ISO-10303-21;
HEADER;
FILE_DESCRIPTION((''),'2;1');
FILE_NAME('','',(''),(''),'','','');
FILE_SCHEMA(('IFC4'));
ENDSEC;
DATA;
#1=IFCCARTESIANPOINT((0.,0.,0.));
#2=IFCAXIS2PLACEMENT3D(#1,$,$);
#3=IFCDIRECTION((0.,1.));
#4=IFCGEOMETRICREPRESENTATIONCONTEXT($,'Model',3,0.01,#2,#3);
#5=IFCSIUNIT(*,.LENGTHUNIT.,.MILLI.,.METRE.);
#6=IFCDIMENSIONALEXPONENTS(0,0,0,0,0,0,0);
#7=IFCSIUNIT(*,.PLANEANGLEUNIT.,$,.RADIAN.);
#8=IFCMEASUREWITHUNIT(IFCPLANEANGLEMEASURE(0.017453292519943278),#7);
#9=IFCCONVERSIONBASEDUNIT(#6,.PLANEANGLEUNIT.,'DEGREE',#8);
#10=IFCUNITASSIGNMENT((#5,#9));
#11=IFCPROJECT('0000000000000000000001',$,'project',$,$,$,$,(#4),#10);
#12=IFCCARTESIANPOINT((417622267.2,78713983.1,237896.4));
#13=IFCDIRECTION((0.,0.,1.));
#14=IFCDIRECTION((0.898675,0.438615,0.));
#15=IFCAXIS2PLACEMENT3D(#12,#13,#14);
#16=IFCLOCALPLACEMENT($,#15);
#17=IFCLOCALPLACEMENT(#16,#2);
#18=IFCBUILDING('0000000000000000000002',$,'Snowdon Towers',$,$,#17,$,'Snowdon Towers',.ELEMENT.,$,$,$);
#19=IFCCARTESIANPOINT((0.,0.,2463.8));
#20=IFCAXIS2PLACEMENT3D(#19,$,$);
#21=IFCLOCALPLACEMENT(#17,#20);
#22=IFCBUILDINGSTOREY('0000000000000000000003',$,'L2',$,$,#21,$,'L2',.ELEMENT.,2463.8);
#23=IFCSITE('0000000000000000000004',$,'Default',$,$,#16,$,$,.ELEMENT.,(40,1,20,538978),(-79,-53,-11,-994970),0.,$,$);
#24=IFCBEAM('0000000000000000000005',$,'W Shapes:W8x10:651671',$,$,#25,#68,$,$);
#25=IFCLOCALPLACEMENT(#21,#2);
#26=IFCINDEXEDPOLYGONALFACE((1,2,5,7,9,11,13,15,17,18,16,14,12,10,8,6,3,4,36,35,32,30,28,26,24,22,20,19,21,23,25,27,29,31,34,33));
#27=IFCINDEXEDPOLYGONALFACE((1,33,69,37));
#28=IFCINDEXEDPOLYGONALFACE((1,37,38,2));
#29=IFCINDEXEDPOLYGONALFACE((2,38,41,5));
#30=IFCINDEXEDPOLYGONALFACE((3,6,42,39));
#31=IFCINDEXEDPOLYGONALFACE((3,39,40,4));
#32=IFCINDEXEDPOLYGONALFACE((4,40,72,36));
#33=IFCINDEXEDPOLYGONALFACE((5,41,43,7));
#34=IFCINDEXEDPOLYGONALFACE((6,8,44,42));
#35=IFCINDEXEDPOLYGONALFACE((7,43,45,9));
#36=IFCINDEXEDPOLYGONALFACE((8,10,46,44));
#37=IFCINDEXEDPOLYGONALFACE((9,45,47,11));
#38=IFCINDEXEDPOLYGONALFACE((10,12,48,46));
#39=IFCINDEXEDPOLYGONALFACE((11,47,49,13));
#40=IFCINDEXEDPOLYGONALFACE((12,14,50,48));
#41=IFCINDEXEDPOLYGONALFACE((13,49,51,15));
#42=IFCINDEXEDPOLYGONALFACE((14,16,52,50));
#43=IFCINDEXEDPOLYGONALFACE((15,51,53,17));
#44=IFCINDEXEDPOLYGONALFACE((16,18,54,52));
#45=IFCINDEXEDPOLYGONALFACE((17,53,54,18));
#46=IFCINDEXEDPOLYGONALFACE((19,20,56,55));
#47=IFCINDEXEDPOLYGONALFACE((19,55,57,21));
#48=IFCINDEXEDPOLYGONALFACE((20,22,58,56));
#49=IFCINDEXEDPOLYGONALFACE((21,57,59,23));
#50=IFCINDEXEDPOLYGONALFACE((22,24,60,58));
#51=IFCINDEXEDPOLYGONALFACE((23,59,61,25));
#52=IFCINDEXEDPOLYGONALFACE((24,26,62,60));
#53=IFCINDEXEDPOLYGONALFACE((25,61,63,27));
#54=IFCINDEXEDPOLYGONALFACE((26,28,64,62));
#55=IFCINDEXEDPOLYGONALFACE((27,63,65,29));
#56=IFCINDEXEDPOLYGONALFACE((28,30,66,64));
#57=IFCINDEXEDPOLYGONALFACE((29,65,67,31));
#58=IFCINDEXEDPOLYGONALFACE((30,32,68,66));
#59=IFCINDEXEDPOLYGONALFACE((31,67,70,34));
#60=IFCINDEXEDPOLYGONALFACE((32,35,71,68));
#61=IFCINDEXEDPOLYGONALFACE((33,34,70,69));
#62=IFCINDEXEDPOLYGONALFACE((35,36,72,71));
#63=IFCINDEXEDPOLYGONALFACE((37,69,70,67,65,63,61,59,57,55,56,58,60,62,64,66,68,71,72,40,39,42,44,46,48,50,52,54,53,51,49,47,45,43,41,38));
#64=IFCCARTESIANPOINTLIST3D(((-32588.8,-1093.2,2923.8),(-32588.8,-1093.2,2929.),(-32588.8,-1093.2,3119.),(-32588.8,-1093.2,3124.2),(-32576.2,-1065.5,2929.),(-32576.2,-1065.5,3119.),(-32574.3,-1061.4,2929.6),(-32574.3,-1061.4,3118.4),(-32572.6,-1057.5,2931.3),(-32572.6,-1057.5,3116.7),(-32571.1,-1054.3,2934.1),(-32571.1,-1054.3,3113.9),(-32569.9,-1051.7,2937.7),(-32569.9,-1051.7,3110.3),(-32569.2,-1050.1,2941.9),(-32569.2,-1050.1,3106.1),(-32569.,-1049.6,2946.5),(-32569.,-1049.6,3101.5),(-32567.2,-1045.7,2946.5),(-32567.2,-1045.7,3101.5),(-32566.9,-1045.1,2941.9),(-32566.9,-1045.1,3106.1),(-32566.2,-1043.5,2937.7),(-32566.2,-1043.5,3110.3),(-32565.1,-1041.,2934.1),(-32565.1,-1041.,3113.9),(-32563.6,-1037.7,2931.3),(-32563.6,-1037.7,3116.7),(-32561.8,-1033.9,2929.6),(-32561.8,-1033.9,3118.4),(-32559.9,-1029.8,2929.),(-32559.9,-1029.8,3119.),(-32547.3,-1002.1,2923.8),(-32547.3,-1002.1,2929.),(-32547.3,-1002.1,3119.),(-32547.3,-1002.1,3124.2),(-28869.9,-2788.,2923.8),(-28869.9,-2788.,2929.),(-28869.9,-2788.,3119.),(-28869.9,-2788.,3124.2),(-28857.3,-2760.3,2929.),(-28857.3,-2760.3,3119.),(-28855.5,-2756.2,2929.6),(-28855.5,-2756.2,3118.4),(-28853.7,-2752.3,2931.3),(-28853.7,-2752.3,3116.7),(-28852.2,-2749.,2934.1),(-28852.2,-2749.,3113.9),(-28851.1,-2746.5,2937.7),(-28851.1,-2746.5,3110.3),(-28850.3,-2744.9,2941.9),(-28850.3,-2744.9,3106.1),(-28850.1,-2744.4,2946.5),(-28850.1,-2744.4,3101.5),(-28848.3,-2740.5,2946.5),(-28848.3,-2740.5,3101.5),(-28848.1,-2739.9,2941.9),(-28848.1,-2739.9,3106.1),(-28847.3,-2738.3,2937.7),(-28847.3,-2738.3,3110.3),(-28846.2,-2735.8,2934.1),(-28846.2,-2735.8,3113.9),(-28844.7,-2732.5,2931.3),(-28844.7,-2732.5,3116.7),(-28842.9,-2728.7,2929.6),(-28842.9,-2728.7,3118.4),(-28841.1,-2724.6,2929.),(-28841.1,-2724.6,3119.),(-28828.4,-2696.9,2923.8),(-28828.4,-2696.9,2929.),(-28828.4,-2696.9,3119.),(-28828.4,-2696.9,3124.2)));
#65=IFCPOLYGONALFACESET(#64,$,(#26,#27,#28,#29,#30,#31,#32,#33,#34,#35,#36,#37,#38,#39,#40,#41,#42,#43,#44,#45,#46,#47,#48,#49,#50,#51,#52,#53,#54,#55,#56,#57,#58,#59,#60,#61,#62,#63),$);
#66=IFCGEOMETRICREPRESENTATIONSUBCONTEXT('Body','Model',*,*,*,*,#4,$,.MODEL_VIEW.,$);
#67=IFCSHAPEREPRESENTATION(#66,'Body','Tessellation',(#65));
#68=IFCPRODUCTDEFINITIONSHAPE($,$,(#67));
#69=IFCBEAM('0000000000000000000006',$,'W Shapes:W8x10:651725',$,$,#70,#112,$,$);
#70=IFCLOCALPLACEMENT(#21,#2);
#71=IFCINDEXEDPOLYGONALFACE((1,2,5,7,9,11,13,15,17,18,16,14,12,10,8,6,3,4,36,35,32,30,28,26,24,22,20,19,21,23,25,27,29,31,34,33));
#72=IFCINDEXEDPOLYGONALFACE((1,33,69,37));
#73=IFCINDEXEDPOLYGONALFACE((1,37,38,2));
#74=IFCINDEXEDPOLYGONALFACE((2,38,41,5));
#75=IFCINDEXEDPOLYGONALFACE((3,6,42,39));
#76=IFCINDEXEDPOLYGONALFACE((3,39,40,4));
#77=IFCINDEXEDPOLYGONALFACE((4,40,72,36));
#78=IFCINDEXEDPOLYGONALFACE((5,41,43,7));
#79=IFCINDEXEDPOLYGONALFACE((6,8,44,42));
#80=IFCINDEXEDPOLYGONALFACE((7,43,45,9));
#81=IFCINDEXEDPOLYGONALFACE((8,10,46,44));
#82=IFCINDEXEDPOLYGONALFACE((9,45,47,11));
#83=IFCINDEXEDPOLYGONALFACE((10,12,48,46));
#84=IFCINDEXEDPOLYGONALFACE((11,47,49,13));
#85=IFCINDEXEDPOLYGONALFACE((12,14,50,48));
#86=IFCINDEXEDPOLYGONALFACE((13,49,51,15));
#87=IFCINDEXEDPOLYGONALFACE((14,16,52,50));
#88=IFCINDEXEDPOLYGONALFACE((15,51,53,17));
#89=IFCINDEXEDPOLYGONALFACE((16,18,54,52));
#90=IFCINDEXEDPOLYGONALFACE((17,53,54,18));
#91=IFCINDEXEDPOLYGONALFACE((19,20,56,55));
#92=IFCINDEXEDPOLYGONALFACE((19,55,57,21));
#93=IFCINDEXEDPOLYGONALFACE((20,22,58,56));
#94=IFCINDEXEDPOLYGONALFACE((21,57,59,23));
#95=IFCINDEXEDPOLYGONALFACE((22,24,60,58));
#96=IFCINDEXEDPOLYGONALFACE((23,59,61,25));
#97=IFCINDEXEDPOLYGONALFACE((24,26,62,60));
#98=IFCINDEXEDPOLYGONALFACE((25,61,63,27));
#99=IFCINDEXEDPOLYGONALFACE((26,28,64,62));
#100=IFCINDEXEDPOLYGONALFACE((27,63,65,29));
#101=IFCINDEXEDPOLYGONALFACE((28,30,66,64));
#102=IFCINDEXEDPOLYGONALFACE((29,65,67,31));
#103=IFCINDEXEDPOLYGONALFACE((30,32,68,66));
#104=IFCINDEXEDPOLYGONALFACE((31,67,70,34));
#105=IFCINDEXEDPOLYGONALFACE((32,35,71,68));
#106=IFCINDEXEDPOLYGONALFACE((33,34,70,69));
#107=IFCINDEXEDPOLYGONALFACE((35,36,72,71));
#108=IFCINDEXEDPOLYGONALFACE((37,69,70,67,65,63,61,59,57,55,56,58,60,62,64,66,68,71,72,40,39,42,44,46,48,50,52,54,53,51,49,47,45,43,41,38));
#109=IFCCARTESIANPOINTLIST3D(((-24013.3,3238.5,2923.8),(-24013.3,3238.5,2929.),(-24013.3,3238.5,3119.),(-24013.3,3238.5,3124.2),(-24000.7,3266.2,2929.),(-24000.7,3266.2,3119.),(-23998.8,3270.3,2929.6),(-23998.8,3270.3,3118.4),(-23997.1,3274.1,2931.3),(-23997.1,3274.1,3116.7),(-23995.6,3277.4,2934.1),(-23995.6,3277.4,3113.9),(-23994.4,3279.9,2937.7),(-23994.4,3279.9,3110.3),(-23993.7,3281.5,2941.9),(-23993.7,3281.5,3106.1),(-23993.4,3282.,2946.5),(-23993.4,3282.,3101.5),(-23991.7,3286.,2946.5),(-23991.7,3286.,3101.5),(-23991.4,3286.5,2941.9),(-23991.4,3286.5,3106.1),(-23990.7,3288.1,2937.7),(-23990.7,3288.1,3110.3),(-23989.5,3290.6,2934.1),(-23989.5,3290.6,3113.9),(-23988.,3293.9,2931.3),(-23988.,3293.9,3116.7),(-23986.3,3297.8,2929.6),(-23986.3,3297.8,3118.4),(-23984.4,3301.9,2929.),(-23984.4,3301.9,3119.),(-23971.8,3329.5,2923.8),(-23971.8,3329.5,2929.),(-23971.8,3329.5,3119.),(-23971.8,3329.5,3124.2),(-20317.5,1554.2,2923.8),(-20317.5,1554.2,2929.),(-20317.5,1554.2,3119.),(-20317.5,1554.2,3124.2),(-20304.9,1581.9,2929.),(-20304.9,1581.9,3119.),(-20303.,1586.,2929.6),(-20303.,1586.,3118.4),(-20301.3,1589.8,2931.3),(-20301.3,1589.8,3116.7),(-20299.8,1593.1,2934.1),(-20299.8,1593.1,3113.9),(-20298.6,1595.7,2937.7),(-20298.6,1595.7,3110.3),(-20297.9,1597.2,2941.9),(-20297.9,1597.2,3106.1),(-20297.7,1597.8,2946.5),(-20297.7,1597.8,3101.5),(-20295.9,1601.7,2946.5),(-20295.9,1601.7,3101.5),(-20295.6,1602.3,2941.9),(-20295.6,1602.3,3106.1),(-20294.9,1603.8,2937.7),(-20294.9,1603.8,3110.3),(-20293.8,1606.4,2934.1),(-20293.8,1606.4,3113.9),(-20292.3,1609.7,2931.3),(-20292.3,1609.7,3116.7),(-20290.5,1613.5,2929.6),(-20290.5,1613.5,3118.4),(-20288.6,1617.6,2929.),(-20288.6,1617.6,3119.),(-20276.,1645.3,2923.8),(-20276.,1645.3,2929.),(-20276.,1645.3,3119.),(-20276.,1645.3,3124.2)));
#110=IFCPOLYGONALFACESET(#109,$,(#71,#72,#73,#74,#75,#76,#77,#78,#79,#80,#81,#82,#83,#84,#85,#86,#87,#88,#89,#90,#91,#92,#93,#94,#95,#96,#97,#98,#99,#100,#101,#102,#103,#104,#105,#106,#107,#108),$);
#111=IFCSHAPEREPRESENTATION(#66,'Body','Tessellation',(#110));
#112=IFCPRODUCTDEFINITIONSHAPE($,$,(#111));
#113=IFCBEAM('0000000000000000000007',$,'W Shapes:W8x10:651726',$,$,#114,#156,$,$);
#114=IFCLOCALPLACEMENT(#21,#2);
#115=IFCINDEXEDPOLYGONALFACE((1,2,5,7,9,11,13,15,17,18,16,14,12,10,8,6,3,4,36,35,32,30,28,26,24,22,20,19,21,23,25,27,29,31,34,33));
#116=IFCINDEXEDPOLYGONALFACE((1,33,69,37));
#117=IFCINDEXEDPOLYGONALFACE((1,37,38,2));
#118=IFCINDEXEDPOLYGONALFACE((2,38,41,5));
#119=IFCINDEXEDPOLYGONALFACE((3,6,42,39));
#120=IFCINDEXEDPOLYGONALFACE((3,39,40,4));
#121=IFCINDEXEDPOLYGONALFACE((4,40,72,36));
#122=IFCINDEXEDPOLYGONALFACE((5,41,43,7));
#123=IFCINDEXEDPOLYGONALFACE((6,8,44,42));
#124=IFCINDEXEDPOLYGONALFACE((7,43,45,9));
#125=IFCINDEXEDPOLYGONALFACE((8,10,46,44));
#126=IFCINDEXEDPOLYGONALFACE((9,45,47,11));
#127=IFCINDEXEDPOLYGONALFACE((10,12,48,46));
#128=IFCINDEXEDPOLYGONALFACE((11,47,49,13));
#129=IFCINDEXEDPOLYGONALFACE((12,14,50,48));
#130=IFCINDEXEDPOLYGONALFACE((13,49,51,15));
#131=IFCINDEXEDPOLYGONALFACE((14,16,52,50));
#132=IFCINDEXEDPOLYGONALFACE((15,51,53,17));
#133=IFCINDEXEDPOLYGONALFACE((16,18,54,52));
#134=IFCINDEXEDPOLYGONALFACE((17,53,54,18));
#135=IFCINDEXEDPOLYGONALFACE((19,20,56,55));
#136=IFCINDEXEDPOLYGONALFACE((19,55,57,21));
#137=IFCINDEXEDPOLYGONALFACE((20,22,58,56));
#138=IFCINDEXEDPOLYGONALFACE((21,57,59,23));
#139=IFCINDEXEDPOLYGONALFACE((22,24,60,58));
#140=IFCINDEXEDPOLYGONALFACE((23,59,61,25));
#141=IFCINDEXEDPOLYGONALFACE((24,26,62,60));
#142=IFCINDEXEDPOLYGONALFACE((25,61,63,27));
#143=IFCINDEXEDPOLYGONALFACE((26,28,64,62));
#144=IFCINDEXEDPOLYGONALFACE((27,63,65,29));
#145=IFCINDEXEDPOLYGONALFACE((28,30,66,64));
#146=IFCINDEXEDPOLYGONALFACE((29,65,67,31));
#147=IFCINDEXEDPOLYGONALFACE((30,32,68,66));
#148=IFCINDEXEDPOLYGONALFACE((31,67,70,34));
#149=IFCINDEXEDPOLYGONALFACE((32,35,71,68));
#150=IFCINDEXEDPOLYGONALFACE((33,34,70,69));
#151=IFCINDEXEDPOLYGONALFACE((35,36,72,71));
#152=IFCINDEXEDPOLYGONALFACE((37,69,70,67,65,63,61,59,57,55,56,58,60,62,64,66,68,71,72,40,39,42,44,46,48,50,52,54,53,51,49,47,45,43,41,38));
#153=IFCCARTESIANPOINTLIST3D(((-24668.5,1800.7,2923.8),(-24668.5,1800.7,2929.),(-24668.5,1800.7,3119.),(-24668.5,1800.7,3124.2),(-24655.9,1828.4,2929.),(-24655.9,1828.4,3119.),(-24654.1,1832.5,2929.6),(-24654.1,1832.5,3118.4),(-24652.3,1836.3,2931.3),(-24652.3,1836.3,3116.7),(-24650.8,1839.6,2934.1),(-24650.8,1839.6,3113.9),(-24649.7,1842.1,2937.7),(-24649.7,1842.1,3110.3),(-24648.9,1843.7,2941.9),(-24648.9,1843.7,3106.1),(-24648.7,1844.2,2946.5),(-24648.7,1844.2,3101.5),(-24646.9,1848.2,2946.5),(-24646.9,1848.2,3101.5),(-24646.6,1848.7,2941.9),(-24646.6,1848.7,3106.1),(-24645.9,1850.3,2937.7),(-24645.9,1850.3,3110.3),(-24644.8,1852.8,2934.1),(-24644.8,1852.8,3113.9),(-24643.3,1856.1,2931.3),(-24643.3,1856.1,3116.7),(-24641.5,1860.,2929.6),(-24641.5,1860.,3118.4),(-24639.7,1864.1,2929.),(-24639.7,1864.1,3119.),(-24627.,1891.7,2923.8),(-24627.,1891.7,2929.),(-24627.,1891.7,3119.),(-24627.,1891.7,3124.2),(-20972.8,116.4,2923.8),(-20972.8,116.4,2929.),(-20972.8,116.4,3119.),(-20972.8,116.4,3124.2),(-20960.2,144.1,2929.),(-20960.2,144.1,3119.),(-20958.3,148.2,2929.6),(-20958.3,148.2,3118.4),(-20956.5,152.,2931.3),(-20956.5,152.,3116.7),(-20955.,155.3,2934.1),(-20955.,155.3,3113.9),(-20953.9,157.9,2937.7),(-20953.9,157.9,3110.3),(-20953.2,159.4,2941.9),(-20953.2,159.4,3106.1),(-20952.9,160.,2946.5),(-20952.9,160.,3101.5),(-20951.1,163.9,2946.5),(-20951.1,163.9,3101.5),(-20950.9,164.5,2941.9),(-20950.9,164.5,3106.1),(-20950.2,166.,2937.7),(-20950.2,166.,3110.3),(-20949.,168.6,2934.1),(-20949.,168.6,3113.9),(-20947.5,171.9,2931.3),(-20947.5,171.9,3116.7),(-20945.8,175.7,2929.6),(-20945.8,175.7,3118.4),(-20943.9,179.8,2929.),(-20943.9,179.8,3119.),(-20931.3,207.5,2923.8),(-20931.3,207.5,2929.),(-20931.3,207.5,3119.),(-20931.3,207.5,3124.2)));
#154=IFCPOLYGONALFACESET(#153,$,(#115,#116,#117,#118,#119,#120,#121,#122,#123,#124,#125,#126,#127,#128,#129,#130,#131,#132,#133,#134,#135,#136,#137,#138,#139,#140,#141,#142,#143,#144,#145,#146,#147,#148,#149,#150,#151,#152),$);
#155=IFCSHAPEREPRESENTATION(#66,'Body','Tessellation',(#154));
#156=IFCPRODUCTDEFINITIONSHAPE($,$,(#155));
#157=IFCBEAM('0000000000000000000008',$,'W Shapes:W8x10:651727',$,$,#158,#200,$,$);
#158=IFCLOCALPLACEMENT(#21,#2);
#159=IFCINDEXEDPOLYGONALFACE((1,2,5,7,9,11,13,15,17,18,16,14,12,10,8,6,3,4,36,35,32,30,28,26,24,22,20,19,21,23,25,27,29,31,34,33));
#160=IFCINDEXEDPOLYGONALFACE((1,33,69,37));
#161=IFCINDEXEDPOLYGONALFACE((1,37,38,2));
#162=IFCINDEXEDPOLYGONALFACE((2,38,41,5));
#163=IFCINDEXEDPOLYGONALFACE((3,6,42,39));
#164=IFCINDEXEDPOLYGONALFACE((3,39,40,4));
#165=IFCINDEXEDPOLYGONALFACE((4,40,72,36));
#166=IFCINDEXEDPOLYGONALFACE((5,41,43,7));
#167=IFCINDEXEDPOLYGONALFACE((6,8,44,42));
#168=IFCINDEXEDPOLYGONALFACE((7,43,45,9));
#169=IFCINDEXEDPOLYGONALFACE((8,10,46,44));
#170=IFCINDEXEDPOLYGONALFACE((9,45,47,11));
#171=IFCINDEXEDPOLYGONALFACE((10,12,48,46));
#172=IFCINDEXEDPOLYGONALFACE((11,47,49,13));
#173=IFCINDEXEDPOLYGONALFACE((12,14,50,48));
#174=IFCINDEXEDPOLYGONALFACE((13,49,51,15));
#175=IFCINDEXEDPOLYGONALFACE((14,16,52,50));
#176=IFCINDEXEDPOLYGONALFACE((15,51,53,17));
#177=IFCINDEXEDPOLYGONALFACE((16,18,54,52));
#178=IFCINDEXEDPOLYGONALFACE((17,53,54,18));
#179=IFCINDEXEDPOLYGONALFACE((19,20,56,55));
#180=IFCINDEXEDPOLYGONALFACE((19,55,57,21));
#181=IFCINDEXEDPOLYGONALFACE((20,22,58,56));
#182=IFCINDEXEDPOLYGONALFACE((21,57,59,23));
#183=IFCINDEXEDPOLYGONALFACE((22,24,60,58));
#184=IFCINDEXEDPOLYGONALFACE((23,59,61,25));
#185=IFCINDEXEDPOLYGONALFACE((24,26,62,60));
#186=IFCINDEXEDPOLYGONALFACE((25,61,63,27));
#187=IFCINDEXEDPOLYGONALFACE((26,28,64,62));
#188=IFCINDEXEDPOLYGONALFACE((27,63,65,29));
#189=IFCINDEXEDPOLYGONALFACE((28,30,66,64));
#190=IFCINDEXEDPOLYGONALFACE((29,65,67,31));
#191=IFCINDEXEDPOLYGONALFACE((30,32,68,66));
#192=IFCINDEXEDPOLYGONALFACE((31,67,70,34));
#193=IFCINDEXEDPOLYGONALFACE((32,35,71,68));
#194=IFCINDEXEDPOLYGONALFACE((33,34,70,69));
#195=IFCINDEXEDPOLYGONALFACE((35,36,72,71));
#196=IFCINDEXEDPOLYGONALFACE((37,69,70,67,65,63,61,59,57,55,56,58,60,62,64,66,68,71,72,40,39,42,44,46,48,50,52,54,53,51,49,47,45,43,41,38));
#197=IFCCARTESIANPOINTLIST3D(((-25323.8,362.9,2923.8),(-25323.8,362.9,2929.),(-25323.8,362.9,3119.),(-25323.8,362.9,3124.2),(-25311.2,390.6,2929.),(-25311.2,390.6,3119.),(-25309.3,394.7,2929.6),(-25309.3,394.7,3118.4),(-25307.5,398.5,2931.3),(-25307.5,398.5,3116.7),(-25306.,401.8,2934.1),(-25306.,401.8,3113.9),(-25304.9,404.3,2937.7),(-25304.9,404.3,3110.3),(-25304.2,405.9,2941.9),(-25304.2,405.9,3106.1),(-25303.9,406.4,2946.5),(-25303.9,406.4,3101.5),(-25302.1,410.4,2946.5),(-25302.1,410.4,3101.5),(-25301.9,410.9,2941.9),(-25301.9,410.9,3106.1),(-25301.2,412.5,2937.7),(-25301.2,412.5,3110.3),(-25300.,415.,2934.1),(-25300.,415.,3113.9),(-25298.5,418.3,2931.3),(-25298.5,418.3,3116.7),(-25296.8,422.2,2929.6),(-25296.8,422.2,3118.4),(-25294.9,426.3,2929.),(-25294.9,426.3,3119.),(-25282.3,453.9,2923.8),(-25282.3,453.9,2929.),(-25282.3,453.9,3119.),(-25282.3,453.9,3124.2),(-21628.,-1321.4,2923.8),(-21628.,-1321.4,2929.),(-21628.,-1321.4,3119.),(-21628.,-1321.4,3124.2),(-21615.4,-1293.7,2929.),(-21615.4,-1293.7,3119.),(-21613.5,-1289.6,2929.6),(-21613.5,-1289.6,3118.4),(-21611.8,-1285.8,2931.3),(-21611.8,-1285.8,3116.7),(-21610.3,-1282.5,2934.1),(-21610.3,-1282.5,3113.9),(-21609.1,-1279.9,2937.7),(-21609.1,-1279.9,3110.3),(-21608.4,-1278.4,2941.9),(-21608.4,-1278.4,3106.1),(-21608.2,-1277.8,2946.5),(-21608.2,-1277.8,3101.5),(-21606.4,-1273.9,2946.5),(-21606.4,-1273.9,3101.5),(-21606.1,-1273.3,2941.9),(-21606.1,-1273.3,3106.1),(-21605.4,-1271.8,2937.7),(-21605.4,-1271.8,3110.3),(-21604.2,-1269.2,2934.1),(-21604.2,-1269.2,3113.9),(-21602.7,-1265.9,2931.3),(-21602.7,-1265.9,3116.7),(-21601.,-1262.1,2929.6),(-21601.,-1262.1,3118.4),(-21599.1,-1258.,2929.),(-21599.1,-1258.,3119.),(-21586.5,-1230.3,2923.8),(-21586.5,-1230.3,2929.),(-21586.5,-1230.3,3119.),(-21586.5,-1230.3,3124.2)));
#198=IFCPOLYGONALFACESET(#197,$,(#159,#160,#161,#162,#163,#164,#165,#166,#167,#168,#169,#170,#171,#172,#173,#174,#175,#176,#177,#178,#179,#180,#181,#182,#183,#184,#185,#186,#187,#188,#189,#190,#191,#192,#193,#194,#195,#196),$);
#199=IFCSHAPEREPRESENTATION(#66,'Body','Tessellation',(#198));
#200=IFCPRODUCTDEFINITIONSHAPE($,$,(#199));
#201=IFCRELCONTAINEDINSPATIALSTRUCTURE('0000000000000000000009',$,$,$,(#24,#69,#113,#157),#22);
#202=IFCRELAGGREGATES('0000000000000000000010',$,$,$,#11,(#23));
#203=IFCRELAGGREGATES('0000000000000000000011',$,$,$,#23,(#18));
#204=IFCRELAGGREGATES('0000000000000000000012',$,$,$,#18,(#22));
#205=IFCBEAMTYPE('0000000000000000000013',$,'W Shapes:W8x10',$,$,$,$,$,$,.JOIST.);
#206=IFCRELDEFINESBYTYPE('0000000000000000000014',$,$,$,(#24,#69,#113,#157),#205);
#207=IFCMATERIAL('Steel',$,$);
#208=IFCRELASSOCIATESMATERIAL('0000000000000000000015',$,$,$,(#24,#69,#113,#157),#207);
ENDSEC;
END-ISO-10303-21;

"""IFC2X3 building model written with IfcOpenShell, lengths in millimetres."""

from ifc_helpers import new_model, entity, si_unit, converted_unit, direction, frame, frame_2d, origin, place, context, subcontext, project, spatial, i_section, extrude, material, type_object, element, save


model = new_model("IFC2X3")

# Units and contexts
model_context = context("Model", 3, precision=0.01, world=origin(), true_north=direction((0.0, 1.0)))
body_context = subcontext(model_context, "Body", "Model", "MODEL_VIEW")
ifc_project = project(units=[si_unit("LENGTHUNIT", "METRE", prefix="MILLI"), converted_unit("PLANEANGLEUNIT", "DEGREE", entity("IfcPlaneAngleMeasure", 0.017453292519943278), si_unit("PLANEANGLEUNIT", "RADIAN"), dimensions=[0, 0, 0, 0, 0, 0, 0])], contexts=[model_context])

# Site, building, storey
site_placement = place(None, frame((417622267.2, 78713983.1, 237896.4), z_axis=(0.0, 0.0, 1.0), x_axis=(0.898675, 0.438615, 0.0)))
site = spatial("IfcSite", under=ifc_project, at=site_placement, Name="Default", CompositionType="ELEMENT", RefLatitude=(40, 1, 20, 538978), RefLongitude=(-79, -53, -11, -994970), RefElevation=0.0)
building_placement = place(site_placement, origin())
building = spatial("IfcBuilding", under=site, at=building_placement, Name="Snowdon Towers", LongName="Snowdon Towers", CompositionType="ELEMENT")
storey_placement = place(building_placement, frame((0.0, 0.0, 2463.8)))
storey = spatial("IfcBuildingStorey", under=building, at=storey_placement, Name="L2", LongName="L2", CompositionType="ELEMENT", Elevation=2463.8)

# Beams
ifc_material = material(Name="Steel")
beam_type_1 = type_object("IfcBeamType", Name="W Shapes:W8x10", PredefinedType="JOIST")
beam_1_placement = place(storey_placement, frame((-32696.4, -989.2, 3124.2), z_axis=(0.0, 0.0, 1.0), x_axis=(0.909961, -0.414693, 0.0)))
element("IfcBeam", 1, at=beam_1_placement, inside=storey, type_object=beam_type_1, material=ifc_material, Name="W Shapes:W8x10:651671", context=body_context, shape_type="SweptSolid", body=[
    extrude(i_section(OverallWidth=100.1, OverallDepth=200.4, WebThickness=4.3, FlangeThickness=5.2, FilletRadius=17.5, at=frame_2d((0.0, 0.0), x_axis=(0.0, 1.0))), frame((141.0, 0.0, -100.2), z_axis=(1.0, 0.0, 0.0), x_axis=(0.0, 0.0, -1.0)), (0.0, 0.0, 1.0), 4086.9),
])
beam_2_placement = place(storey_placement, frame((-24120.8, 3342.5, 3124.2), z_axis=(0.0, 0.0, 1.0), x_axis=(0.909961, -0.414693, 0.0)))
element("IfcBeam", 2, at=beam_2_placement, inside=storey, type_object=beam_type_1, material=ifc_material, Name="W Shapes:W8x10:651725", context=body_context, shape_type="SweptSolid", body=[
    extrude(i_section(OverallWidth=100.1, OverallDepth=200.4, WebThickness=4.3, FlangeThickness=5.2, FilletRadius=17.5, at=frame_2d((0.0, 0.0), x_axis=(0.0, 1.0))), frame((141.0, 0.0, -100.2), z_axis=(1.0, 0.0, 0.0), x_axis=(0.0, 0.0, -1.0)), (0.0, 0.0, 1.0), 4061.5),
])
beam_3_placement = place(storey_placement, frame((-24776.1, 1904.7, 3124.2), z_axis=(0.0, 0.0, 1.0), x_axis=(0.909961, -0.414693, 0.0)))
element("IfcBeam", 3, at=beam_3_placement, inside=storey, type_object=beam_type_1, material=ifc_material, Name="W Shapes:W8x10:651726", context=body_context, shape_type="SweptSolid", body=[
    extrude(i_section(OverallWidth=100.1, OverallDepth=200.4, WebThickness=4.3, FlangeThickness=5.2, FilletRadius=17.5, at=frame_2d((0.0, 0.0), x_axis=(0.0, 1.0))), frame((141.0, 0.0, -100.2), z_axis=(1.0, 0.0, 0.0), x_axis=(0.0, 0.0, -1.0)), (0.0, 0.0, 1.0), 4061.5),
])
beam_4_placement = place(storey_placement, frame((-25431.3, 466.9, 3124.2), z_axis=(0.0, 0.0, 1.0), x_axis=(0.909961, -0.414693, 0.0)))
element("IfcBeam", 4, at=beam_4_placement, inside=storey, type_object=beam_type_1, material=ifc_material, Name="W Shapes:W8x10:651727", context=body_context, shape_type="SweptSolid", body=[
    extrude(i_section(OverallWidth=100.1, OverallDepth=200.4, WebThickness=4.3, FlangeThickness=5.2, FilletRadius=17.5, at=frame_2d((0.0, 0.0), x_axis=(0.0, 1.0))), frame((141.0, 0.0, -100.2), z_axis=(1.0, 0.0, 0.0), x_axis=(0.0, 0.0, -1.0)), (0.0, 0.0, 1.0), 4061.5),
])

save(model, "model.ifc")
